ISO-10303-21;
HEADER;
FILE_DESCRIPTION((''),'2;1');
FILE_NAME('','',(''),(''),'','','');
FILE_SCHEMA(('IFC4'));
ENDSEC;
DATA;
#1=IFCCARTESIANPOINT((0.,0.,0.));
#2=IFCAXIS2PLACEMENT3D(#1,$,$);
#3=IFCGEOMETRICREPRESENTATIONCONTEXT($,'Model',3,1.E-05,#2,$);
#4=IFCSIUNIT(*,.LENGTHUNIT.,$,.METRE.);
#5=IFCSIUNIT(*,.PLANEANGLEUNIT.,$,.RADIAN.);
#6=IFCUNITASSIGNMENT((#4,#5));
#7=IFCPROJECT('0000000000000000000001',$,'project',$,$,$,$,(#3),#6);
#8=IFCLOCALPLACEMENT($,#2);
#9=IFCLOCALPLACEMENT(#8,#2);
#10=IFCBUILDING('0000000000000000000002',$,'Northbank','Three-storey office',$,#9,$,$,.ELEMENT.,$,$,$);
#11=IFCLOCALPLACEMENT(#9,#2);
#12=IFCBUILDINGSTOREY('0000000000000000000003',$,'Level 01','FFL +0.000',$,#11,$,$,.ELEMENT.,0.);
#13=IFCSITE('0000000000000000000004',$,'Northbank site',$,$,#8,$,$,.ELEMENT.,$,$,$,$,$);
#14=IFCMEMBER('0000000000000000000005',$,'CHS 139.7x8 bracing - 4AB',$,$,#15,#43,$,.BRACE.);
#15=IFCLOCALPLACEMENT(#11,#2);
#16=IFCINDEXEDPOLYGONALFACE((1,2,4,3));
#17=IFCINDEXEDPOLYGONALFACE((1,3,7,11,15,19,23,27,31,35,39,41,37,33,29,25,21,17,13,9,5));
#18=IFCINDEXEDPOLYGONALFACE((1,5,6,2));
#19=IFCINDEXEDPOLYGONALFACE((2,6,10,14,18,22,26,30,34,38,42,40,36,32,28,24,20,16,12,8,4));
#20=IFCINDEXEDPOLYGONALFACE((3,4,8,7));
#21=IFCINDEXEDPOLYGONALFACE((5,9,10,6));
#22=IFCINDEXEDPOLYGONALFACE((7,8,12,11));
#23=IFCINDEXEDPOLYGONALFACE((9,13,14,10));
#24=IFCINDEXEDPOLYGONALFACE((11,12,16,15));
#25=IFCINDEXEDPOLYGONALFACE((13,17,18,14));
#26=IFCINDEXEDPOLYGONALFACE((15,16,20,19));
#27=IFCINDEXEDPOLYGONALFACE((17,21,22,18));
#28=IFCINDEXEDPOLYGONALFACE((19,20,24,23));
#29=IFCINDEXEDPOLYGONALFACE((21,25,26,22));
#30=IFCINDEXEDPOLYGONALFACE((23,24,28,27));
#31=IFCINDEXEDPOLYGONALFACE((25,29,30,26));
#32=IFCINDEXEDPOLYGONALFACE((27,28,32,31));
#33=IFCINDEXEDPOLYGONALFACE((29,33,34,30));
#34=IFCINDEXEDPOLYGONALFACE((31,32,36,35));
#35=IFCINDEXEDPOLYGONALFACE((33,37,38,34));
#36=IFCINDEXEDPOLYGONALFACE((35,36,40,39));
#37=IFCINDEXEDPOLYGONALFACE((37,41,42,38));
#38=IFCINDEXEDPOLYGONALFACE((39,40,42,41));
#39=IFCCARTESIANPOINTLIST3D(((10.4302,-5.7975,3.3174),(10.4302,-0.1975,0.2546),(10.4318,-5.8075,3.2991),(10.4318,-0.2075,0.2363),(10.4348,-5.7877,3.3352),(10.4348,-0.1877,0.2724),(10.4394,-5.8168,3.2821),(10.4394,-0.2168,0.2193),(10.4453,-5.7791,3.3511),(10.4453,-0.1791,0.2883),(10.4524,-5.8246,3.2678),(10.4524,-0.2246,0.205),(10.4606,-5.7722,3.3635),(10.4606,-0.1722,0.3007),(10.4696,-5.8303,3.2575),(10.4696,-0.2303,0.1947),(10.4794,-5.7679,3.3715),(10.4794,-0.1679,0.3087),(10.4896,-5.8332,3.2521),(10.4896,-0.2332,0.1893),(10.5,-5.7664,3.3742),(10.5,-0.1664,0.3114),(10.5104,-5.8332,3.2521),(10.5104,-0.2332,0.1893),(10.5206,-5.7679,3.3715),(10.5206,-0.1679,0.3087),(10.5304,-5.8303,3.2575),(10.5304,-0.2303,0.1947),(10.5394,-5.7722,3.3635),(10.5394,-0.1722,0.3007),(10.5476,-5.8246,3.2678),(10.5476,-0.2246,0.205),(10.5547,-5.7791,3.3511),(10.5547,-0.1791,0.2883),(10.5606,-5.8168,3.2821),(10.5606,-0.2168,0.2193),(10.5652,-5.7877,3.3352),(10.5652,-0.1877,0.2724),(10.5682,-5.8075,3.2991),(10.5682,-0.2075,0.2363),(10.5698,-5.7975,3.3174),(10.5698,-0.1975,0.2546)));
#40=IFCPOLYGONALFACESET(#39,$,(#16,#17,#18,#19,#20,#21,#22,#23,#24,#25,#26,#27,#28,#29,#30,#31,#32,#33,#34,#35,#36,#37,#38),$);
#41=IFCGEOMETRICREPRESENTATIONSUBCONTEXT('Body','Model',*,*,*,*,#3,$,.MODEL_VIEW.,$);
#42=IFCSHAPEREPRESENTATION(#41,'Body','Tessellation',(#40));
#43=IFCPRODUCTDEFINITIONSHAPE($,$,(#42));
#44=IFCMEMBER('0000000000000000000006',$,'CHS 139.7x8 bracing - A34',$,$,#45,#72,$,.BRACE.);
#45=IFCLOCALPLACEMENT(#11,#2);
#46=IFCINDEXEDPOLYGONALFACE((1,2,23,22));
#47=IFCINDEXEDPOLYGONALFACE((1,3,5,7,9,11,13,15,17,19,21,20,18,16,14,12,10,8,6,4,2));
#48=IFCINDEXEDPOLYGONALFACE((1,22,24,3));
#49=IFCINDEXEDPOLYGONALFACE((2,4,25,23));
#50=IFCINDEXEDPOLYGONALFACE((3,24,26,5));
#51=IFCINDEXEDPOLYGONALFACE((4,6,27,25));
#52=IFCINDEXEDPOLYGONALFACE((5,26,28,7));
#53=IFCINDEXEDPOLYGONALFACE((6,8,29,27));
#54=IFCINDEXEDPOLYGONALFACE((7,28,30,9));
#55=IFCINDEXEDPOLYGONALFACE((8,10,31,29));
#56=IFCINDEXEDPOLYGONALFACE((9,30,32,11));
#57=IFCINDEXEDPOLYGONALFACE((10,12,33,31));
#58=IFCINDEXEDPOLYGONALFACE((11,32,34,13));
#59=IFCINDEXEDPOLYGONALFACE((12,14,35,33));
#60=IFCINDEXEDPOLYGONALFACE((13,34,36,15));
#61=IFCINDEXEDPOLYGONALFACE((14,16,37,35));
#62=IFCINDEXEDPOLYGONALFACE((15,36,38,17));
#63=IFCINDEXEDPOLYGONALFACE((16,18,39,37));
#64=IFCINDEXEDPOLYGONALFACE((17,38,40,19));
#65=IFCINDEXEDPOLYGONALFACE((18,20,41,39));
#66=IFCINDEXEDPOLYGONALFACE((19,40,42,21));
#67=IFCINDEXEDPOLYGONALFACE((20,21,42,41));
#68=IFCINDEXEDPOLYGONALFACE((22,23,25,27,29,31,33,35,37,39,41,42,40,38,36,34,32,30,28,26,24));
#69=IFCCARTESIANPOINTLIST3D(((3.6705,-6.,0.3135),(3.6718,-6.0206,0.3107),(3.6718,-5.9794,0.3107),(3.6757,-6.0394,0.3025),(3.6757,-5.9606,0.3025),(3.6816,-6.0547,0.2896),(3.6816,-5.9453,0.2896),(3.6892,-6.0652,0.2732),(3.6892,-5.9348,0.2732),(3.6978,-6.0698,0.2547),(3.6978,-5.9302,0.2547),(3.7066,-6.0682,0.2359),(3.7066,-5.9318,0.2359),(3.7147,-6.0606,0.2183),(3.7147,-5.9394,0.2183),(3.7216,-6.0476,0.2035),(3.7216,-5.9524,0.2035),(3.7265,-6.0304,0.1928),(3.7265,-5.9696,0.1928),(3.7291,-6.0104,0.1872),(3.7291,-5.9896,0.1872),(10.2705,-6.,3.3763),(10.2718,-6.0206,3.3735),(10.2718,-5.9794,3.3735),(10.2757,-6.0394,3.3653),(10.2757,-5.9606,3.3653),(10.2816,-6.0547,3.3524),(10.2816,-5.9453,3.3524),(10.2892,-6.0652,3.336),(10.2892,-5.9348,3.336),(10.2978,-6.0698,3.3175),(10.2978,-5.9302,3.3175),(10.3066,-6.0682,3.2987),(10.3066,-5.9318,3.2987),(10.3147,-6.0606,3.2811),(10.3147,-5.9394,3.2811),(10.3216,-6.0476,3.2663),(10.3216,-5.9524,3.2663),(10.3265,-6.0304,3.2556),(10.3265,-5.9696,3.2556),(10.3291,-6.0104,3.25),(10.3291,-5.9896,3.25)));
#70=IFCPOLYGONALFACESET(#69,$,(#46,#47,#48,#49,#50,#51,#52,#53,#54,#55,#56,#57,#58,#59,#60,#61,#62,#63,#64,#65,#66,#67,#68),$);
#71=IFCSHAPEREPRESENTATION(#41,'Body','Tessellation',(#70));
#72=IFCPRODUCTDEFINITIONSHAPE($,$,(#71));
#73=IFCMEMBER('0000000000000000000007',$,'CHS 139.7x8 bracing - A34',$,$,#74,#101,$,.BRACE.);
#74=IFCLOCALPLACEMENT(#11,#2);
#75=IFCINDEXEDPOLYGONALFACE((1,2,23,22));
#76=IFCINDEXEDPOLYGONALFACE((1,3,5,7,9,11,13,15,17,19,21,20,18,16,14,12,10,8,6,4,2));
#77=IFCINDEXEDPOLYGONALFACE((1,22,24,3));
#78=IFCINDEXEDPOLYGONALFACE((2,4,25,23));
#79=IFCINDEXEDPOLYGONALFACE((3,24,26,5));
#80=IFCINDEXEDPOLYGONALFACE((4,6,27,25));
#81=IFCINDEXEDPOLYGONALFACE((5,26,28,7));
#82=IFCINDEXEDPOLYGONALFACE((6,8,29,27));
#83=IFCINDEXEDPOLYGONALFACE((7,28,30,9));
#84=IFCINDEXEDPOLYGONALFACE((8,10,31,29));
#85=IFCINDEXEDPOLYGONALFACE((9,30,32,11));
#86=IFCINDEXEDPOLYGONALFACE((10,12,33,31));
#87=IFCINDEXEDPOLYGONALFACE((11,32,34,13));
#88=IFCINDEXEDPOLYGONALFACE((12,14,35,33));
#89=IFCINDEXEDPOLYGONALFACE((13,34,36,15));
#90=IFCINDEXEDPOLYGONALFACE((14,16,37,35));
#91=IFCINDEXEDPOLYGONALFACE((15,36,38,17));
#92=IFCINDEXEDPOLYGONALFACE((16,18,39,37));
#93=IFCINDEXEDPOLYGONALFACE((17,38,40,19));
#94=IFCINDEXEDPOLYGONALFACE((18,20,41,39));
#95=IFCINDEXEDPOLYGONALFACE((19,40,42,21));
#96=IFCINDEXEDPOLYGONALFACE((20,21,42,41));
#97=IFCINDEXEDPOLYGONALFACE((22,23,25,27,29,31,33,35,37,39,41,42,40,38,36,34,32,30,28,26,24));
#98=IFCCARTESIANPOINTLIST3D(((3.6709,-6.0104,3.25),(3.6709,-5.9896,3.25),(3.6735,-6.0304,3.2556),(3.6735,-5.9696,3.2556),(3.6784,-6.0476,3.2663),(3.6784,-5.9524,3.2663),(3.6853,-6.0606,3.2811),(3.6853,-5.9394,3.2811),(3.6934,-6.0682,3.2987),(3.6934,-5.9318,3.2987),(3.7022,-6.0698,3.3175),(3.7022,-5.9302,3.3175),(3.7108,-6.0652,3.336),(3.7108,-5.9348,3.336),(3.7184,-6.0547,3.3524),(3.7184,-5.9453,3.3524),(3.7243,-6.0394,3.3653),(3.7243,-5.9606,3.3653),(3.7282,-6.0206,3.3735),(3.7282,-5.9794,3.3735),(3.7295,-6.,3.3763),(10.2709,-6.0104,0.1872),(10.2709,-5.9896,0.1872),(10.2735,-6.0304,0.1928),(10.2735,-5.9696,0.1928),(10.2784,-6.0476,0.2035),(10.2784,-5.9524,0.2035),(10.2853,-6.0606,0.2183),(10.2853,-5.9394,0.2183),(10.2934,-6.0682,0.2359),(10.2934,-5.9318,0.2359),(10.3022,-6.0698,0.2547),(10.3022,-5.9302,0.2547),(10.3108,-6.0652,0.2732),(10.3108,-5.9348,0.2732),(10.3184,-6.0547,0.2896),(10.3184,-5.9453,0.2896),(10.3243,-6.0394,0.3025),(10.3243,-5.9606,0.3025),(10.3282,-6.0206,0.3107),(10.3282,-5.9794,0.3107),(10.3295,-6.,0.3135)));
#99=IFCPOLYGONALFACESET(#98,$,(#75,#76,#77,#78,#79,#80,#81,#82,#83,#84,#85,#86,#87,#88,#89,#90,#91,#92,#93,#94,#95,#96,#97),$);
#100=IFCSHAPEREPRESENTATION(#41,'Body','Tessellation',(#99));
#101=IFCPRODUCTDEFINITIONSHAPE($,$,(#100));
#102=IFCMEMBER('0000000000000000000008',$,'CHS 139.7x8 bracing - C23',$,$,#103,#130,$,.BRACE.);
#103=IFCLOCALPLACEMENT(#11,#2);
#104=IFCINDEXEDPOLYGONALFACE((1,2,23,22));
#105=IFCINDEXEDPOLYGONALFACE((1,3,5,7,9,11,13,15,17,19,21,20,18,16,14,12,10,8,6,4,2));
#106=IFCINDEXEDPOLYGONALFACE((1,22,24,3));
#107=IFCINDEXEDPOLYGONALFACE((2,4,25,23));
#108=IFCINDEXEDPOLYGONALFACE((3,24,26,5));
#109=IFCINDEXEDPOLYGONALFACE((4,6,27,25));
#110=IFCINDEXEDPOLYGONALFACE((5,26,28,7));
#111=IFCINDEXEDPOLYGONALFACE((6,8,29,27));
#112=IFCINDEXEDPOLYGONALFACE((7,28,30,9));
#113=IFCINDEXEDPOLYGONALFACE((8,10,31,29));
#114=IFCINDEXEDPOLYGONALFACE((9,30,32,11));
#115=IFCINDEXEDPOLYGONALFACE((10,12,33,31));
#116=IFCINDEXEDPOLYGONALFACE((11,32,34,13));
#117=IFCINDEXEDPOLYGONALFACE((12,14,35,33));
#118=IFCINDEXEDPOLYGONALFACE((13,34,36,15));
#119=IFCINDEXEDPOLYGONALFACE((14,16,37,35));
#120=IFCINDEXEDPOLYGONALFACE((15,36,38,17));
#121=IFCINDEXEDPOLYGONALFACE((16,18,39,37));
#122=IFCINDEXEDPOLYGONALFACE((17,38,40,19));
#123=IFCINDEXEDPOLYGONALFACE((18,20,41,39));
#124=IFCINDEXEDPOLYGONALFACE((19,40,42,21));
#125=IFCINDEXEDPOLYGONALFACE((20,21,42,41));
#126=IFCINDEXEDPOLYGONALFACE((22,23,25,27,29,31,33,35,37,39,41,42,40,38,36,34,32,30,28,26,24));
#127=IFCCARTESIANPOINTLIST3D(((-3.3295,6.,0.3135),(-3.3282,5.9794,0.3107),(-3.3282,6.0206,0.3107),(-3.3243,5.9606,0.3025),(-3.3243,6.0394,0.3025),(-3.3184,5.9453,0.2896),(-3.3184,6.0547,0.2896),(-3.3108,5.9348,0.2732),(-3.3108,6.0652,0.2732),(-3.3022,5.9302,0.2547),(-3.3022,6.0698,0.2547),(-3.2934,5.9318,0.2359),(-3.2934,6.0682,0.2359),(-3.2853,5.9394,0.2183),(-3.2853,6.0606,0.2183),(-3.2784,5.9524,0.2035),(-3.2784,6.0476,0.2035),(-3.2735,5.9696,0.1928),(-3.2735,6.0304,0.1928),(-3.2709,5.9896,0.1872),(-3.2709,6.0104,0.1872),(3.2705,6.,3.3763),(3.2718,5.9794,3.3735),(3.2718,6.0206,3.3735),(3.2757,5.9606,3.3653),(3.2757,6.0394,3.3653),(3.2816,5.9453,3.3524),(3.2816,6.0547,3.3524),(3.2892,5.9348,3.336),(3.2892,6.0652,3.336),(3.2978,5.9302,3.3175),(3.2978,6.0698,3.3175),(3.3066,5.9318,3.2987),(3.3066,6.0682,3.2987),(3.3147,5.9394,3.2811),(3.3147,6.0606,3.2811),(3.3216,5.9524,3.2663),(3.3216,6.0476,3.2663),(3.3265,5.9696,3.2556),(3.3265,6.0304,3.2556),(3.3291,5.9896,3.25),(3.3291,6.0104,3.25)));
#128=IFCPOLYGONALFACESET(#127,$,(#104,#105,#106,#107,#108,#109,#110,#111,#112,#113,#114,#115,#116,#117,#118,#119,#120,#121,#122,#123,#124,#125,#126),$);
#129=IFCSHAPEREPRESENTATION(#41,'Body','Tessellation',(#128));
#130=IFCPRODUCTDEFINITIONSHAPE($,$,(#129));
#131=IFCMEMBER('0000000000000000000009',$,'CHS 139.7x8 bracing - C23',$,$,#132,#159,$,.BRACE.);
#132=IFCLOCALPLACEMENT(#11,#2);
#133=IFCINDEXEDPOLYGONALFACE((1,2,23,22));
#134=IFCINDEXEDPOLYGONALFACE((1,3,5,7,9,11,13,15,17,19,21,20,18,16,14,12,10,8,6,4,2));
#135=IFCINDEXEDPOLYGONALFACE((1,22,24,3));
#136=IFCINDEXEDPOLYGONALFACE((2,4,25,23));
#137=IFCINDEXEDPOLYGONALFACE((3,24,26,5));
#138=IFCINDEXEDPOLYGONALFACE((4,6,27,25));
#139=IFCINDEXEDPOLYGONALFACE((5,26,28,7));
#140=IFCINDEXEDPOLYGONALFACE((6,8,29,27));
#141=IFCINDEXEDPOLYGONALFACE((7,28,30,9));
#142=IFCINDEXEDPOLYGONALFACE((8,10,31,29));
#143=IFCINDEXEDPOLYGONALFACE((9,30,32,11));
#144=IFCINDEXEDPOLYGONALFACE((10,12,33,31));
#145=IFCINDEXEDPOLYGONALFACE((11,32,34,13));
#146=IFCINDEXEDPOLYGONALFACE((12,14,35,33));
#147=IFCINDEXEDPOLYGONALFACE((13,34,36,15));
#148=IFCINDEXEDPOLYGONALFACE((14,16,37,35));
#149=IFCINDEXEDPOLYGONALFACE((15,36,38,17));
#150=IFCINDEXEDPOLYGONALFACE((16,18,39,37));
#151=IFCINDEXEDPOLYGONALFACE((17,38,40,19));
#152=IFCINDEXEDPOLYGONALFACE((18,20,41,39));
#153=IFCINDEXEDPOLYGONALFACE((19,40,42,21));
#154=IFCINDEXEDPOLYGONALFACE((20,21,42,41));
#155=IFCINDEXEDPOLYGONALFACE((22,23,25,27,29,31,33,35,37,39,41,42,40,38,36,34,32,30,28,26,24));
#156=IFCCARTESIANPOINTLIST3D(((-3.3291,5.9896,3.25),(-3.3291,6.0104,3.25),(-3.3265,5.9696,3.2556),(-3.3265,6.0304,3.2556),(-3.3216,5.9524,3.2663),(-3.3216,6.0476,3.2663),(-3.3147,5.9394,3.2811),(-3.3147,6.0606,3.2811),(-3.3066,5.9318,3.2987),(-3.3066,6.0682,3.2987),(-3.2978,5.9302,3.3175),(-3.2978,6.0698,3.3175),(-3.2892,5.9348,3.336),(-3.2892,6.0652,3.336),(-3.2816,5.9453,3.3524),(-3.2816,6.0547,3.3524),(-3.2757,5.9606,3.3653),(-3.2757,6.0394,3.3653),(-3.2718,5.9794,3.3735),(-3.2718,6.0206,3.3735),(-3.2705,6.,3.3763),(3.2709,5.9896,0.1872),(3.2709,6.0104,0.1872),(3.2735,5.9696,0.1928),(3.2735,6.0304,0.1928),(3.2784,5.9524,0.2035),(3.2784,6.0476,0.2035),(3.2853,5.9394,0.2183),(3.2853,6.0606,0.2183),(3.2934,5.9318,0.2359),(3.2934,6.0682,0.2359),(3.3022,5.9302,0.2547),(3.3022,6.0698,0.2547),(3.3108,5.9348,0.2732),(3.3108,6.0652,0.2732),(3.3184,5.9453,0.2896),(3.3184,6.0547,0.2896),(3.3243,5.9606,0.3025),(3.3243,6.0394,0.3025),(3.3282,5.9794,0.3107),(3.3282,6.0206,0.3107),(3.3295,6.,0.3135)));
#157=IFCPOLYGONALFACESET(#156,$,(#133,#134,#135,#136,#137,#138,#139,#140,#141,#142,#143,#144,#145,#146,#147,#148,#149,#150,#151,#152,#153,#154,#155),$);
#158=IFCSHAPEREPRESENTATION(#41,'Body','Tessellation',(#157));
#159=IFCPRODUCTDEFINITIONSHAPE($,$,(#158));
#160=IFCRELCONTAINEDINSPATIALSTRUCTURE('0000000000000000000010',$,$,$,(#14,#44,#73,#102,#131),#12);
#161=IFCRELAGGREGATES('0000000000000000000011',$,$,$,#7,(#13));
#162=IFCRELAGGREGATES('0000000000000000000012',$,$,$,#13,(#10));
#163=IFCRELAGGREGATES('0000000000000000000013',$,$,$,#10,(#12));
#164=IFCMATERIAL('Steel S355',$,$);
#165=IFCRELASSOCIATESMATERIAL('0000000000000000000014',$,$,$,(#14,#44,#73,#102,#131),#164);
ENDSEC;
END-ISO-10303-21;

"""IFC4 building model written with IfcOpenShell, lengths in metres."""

from ifc_helpers import new_model, si_unit, frame, origin, place, context, subcontext, project, spatial, circle, extrude, material, element, save


model = new_model("IFC4")

# Units and contexts
model_context = context("Model", 3, precision=1e-05, world=origin())
body_context = subcontext(model_context, "Body", "Model", "MODEL_VIEW")
ifc_project = project(units=[si_unit("LENGTHUNIT", "METRE"), si_unit("PLANEANGLEUNIT", "RADIAN")], contexts=[model_context])

# Site, building, storey
site_placement = place(None, origin())
site = spatial("IfcSite", under=ifc_project, at=site_placement, Name="Northbank site", CompositionType="ELEMENT")
building_placement = place(site_placement, origin())
building = spatial("IfcBuilding", under=site, at=building_placement, Name="Northbank", Description="Three-storey office", CompositionType="ELEMENT")
storey_placement = place(building_placement, origin())
storey = spatial("IfcBuildingStorey", under=building, at=storey_placement, Name="Level 01", Description="FFL +0.000", CompositionType="ELEMENT", Elevation=0.0)

# Shared definitions
ifc_material = material(Name="Steel S355")

# Members
member_1_placement = place(storey_placement, origin())
element("IfcMember", 1, at=member_1_placement, inside=storey, material=ifc_material, Name="CHS 139.7x8 bracing - 4AB", PredefinedType="BRACE", context=body_context, shape_type="SweptSolid", body=[
    extrude(circle(Radius=0.07), frame((10.5, -0.2, 0.25), z_axis=(0.0, -0.877351, 0.479849), x_axis=(0.0, 0.479849, 0.877351)), (0.0, 0.0, 1.0), 6.3828),
])
member_2_placement = place(storey_placement, origin())
element("IfcMember", 2, at=member_2_placement, inside=storey, material=ifc_material, Name="CHS 139.7x8 bracing - A34", PredefinedType="BRACE", context=body_context, shape_type="SweptSolid", body=[
    extrude(circle(Radius=0.07), frame((3.7, -6.0, 0.25), z_axis=(0.907087, 0.0, 0.420943), x_axis=(-0.420943, 0.0, 0.907087)), (0.0, 0.0, 1.0), 7.276),
])
member_3_placement = place(storey_placement, origin())
element("IfcMember", 3, at=member_3_placement, inside=storey, material=ifc_material, Name="CHS 139.7x8 bracing - A34", PredefinedType="BRACE", context=body_context, shape_type="SweptSolid", body=[
    extrude(circle(Radius=0.07), frame((10.3, -6.0, 0.25), z_axis=(-0.907087, 0.0, 0.420943), x_axis=(0.420943, 0.0, 0.907087)), (0.0, 0.0, 1.0), 7.276),
])
member_4_placement = place(storey_placement, origin())
element("IfcMember", 4, at=member_4_placement, inside=storey, material=ifc_material, Name="CHS 139.7x8 bracing - C23", PredefinedType="BRACE", context=body_context, shape_type="SweptSolid", body=[
    extrude(circle(Radius=0.07), frame((-3.3, 6.0, 0.25), z_axis=(0.907087, 0.0, 0.420943), x_axis=(-0.420943, 0.0, 0.907087)), (0.0, 0.0, 1.0), 7.276),
])
member_5_placement = place(storey_placement, origin())
element("IfcMember", 5, at=member_5_placement, inside=storey, material=ifc_material, Name="CHS 139.7x8 bracing - C23", PredefinedType="BRACE", context=body_context, shape_type="SweptSolid", body=[
    extrude(circle(Radius=0.07), frame((3.3, 6.0, 0.25), z_axis=(-0.907087, 0.0, 0.420943), x_axis=(0.420943, 0.0, 0.907087)), (0.0, 0.0, 1.0), 7.276),
])

save(model, "model.ifc")
